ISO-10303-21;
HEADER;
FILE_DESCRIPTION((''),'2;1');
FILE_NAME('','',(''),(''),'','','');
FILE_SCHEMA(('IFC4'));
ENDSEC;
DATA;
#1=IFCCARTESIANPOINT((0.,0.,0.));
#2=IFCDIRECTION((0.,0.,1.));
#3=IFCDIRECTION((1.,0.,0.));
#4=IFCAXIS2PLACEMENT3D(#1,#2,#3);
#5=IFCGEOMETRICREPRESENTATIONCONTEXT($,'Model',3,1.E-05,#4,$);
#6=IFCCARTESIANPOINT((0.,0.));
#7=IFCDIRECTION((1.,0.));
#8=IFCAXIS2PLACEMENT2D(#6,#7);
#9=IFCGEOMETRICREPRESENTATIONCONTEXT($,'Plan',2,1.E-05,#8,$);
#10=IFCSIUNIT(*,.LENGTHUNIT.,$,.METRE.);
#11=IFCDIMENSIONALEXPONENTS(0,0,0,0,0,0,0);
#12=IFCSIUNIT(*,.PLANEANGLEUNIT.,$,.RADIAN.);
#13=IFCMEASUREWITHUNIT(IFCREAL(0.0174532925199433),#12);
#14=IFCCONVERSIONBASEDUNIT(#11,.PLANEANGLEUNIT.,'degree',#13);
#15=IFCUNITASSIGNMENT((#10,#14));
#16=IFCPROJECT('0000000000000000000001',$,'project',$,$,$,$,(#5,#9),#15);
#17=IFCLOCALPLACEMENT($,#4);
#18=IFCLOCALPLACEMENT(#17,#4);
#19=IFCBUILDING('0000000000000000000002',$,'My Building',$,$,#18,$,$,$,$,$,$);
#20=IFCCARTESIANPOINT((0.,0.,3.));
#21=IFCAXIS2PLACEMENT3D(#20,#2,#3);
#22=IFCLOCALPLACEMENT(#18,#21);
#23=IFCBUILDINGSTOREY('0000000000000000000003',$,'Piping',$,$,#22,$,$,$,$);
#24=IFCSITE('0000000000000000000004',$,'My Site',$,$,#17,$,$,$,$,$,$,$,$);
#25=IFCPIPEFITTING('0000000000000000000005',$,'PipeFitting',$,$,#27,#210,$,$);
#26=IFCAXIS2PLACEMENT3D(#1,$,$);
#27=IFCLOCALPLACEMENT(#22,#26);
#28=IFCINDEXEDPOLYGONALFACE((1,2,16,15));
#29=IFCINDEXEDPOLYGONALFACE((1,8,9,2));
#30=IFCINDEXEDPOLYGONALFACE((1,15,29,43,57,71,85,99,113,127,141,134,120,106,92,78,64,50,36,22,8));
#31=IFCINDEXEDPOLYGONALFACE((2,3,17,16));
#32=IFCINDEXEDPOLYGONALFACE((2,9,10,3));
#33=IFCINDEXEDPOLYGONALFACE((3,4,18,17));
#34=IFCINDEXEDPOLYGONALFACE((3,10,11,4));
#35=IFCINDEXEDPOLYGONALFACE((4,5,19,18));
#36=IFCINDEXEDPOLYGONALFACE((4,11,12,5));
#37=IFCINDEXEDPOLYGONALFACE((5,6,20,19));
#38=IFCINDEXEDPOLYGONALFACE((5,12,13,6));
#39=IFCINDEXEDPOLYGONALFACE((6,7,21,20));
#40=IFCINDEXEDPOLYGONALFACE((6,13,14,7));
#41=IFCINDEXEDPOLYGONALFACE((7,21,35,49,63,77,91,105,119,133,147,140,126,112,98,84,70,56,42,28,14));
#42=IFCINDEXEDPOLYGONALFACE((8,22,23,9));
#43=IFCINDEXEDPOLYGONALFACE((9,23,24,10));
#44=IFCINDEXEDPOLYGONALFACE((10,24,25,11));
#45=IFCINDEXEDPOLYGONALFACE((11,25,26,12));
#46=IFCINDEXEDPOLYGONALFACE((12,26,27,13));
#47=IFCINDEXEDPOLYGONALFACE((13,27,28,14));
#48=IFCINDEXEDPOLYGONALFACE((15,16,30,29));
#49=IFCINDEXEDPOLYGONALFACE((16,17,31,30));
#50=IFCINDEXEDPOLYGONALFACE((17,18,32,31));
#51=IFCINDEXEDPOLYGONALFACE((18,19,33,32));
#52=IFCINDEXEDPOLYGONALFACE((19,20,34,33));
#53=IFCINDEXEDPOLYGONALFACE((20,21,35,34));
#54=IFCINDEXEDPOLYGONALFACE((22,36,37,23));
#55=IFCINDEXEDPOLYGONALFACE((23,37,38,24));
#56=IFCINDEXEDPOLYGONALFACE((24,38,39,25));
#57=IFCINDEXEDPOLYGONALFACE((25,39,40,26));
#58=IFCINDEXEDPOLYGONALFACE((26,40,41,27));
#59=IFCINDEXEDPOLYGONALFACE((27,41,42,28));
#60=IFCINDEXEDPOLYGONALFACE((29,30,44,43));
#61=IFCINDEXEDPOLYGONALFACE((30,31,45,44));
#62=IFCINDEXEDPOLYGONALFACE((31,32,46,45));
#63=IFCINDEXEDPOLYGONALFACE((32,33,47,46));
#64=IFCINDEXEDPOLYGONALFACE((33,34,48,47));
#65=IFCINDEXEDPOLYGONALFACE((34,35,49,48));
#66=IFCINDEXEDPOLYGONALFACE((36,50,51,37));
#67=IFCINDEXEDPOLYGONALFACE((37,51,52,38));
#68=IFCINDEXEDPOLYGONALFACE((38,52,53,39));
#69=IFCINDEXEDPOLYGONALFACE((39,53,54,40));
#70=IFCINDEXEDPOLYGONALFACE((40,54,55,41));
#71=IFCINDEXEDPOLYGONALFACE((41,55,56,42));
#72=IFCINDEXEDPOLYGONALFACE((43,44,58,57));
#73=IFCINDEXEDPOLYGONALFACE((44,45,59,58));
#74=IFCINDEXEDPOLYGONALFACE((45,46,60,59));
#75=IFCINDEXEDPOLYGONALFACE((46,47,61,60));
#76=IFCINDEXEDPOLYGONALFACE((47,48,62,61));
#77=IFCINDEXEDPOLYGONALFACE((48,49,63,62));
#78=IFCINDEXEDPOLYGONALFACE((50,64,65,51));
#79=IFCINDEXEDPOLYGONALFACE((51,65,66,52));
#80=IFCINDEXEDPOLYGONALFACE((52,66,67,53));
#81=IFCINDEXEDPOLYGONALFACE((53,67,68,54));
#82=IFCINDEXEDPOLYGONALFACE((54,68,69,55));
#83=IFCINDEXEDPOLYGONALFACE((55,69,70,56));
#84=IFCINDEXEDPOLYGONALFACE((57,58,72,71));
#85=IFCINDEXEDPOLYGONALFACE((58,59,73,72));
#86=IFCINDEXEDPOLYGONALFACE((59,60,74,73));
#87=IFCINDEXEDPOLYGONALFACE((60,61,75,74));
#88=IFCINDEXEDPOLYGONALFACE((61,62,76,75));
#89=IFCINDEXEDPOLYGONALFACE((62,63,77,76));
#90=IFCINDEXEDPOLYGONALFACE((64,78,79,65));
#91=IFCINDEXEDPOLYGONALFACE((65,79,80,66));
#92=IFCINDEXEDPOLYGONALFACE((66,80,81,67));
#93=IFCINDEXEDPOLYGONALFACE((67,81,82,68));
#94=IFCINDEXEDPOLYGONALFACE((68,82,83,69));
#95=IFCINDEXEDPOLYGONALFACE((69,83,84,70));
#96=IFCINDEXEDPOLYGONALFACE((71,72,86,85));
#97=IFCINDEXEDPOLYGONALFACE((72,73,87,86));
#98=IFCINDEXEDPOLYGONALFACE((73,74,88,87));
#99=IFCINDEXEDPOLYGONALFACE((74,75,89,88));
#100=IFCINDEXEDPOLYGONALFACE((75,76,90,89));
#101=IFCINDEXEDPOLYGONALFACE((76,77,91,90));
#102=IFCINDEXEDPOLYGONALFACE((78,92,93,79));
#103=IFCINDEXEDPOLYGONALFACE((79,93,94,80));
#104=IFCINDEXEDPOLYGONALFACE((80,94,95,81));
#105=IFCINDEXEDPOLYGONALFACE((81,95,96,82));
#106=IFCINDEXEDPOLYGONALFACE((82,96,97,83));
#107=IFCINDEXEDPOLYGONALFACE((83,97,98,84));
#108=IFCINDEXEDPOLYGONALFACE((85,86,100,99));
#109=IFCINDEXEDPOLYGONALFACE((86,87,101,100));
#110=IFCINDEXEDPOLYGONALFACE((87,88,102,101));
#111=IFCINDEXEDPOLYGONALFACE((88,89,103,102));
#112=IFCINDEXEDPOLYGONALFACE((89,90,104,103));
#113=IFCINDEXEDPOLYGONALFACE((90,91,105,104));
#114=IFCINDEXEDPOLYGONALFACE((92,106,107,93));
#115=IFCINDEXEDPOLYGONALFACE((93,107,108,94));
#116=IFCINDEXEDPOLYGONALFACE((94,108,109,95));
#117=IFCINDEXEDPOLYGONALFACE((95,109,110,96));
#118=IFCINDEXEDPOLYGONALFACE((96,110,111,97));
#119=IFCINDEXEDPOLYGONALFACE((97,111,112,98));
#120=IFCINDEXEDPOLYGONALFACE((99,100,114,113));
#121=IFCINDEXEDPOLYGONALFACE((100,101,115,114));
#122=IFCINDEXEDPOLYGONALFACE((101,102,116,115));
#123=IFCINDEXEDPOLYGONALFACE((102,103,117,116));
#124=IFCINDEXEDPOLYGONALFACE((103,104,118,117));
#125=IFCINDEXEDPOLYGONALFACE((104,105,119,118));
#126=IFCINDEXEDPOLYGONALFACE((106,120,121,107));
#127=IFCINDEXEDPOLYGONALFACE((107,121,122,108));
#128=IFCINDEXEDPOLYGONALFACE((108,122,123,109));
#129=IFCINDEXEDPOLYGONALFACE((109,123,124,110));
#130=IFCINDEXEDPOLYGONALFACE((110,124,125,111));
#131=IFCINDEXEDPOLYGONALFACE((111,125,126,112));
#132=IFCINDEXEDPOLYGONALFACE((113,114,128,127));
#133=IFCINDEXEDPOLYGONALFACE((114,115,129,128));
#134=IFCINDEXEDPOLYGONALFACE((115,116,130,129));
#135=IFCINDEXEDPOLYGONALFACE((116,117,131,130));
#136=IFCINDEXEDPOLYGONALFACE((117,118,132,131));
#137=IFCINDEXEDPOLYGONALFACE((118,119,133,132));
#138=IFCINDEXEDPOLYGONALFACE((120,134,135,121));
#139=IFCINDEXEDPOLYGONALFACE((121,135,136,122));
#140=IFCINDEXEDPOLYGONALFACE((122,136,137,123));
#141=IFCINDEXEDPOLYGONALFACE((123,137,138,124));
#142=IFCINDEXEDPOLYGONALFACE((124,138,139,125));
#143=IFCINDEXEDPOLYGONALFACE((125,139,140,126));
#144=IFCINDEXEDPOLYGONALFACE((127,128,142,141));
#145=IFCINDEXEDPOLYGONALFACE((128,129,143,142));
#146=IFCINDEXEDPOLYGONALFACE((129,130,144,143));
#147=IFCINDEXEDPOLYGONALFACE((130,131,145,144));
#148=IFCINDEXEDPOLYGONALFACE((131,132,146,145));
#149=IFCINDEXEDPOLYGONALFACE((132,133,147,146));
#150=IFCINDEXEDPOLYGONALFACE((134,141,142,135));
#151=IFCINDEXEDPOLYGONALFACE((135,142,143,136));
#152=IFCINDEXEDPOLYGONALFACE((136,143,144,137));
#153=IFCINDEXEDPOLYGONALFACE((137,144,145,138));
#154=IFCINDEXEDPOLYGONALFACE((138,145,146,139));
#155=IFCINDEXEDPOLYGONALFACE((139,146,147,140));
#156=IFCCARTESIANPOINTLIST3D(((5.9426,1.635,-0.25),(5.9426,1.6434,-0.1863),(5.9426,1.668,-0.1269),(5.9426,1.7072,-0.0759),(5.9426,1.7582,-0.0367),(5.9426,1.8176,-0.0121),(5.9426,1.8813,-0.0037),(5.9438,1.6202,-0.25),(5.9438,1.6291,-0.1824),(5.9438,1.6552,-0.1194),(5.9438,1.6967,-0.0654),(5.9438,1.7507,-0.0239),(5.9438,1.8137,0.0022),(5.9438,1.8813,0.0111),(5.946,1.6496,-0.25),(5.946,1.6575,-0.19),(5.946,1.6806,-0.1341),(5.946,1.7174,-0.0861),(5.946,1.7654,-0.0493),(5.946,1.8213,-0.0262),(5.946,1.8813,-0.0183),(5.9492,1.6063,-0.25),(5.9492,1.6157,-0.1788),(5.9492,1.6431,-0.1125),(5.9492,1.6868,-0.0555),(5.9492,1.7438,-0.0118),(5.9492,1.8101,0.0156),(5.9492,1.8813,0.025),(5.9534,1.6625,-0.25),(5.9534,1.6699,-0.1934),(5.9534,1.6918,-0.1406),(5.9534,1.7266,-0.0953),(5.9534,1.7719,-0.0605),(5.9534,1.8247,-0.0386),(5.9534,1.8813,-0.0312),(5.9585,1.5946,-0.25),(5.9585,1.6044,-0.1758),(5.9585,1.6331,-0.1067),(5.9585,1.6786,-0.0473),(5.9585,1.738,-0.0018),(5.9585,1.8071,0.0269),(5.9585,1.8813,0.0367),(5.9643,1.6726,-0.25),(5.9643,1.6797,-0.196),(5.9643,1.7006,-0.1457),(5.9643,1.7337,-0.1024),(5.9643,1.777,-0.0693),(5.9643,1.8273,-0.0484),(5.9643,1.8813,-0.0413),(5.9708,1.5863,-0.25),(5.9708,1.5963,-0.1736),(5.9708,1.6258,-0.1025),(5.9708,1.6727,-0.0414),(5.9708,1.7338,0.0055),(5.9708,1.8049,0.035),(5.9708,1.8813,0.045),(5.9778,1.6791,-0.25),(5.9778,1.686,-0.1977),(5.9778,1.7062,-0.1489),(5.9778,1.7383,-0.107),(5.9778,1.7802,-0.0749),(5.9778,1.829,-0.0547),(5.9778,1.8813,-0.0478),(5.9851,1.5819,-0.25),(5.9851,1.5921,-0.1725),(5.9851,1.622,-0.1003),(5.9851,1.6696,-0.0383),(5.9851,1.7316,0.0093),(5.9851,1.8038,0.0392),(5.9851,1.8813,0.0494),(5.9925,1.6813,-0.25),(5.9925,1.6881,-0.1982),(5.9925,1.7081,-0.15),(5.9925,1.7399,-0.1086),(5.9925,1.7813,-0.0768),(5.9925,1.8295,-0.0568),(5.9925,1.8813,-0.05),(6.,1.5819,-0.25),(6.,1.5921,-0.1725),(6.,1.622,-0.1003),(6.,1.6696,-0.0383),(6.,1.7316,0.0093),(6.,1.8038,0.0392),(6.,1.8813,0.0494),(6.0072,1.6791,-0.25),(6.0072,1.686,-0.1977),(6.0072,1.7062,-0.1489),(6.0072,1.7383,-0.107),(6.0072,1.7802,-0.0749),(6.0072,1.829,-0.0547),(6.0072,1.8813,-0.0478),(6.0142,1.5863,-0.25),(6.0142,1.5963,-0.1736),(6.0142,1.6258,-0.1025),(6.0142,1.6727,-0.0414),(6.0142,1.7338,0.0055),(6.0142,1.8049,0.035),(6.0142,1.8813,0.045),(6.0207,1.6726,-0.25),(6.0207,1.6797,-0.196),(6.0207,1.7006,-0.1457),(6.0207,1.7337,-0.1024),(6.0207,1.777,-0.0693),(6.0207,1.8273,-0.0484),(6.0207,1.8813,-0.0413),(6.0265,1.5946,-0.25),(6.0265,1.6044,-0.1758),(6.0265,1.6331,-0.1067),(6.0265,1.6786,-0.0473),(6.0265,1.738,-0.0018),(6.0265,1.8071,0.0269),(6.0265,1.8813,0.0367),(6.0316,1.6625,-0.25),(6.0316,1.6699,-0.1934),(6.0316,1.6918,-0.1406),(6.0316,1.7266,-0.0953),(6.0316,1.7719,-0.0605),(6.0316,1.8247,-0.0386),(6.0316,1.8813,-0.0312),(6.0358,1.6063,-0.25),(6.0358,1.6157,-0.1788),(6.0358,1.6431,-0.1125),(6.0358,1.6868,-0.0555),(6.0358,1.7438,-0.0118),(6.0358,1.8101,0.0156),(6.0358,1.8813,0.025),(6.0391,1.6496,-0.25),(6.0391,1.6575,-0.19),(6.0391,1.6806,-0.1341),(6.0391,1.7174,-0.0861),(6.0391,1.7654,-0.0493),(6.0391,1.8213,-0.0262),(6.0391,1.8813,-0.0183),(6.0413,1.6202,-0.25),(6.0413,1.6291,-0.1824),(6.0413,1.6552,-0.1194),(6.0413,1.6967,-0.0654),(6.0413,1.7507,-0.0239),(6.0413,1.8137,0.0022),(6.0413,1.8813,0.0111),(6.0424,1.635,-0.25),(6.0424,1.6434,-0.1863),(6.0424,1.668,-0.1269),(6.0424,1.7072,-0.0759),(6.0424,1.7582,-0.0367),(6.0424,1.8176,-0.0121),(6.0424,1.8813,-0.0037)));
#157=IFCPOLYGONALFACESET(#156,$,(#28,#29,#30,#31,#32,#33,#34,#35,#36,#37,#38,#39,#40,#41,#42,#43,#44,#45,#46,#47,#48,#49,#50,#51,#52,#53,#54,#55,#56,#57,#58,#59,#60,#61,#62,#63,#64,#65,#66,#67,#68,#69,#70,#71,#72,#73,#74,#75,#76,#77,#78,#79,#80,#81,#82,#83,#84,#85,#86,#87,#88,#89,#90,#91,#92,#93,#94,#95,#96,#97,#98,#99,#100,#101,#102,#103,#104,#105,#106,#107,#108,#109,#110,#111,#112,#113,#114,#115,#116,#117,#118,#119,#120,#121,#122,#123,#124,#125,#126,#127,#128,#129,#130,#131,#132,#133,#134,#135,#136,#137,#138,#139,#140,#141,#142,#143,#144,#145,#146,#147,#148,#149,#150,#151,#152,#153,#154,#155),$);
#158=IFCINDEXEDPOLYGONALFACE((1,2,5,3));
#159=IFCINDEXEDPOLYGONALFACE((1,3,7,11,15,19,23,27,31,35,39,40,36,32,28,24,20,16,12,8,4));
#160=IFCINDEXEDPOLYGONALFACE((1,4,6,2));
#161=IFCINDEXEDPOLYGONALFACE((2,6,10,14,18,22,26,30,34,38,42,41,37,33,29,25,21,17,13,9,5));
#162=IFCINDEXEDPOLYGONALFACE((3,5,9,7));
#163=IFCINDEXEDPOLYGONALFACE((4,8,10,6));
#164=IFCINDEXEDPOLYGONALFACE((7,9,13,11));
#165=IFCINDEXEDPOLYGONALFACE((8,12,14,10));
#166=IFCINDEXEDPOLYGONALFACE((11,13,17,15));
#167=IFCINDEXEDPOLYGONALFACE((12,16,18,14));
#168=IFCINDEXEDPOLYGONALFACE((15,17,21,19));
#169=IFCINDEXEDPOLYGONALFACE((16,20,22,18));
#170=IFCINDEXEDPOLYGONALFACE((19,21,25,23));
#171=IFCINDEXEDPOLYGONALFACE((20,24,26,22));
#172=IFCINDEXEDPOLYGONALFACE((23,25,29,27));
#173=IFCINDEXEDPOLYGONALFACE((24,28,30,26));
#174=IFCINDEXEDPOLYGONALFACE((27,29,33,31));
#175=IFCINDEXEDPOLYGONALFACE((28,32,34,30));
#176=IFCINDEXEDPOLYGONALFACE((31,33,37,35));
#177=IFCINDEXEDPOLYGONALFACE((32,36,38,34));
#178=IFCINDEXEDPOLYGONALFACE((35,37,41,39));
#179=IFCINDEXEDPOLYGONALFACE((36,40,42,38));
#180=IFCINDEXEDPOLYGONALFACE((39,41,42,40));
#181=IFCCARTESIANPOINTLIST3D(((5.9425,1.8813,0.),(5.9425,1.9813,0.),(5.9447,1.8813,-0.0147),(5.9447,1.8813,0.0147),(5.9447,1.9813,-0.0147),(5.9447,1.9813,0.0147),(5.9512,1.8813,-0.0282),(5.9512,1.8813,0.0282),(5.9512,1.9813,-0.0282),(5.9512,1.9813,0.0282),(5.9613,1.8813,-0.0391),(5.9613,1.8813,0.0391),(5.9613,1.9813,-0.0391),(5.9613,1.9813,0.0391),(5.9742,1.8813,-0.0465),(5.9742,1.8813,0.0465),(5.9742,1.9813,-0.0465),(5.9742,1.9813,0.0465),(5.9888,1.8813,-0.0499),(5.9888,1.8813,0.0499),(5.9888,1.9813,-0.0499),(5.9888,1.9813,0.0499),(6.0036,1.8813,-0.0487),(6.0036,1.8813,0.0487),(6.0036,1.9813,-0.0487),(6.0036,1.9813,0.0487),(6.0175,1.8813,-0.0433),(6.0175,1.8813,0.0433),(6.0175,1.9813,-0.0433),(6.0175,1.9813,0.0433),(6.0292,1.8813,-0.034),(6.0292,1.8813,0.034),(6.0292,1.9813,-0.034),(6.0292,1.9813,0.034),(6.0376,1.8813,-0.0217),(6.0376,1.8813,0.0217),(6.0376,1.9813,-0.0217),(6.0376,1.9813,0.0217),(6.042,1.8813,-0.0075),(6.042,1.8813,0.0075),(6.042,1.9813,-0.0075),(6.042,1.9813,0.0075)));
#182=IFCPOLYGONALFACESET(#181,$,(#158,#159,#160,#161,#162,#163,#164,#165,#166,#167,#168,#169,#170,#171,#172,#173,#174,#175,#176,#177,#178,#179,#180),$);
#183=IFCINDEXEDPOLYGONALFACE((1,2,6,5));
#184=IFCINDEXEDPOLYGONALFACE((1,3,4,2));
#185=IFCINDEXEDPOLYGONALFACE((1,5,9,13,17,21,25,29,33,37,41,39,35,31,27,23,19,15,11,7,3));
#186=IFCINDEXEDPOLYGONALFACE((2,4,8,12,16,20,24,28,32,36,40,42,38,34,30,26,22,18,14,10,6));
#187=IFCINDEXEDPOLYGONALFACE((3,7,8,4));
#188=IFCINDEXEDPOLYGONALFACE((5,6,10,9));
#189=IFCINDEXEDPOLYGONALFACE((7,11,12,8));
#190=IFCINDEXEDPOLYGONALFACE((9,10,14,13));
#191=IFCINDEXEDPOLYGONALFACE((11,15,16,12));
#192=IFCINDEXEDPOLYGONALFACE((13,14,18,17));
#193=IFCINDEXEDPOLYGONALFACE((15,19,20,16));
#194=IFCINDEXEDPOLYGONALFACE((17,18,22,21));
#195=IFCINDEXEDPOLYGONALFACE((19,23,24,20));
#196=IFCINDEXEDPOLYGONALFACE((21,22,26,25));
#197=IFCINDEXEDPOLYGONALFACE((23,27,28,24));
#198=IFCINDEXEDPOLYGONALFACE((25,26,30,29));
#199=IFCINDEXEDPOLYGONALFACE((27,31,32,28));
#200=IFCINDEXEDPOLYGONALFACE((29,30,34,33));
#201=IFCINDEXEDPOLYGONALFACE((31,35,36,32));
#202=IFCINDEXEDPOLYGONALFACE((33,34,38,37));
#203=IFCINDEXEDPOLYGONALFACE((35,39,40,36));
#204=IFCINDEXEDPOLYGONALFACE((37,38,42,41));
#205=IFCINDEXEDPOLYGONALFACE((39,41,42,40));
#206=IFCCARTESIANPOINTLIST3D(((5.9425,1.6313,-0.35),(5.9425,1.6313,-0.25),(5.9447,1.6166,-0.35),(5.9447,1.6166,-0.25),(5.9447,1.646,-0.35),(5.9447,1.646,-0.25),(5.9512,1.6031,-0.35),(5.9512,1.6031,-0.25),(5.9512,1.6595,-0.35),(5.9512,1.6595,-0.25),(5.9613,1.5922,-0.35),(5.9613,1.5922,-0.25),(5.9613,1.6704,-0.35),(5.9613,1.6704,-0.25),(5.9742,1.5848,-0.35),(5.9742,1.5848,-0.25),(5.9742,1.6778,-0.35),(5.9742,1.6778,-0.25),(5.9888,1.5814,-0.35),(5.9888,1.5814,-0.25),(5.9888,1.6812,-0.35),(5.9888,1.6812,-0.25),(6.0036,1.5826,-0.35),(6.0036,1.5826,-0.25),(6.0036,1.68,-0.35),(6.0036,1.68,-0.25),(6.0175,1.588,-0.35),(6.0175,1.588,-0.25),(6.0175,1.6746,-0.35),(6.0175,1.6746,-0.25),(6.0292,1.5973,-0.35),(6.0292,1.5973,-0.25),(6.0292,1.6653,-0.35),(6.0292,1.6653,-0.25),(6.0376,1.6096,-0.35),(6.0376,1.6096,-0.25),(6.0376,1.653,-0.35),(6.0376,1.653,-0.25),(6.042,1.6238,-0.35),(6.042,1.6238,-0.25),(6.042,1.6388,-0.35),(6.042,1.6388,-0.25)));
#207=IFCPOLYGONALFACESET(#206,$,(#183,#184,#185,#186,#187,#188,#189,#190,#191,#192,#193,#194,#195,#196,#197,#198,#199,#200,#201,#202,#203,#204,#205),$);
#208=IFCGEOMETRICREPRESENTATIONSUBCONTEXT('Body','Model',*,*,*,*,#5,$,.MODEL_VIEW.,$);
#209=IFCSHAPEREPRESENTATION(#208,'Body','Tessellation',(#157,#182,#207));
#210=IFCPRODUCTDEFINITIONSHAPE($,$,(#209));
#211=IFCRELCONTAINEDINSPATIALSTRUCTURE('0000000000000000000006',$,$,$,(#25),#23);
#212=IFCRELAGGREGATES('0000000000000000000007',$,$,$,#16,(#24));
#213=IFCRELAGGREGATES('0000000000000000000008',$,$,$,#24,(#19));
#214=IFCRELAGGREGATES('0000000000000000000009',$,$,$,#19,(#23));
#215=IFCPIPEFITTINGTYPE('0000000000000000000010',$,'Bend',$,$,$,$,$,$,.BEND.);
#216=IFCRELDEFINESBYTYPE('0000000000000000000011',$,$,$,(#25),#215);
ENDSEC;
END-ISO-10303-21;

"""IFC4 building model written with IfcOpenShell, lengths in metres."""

from ifc_helpers import new_model, entity, si_unit, converted_unit, frame, origin_with_axes, origin_2d_with_axis, place, context, subcontext, project, spatial, circle, extrude, source, transform, mapped, type_object, type_shapes, element, save


model = new_model("IFC4")

# Units and contexts
model_context = context("Model", 3, precision=1e-05, world=origin_with_axes())
plan_context = context("Plan", 2, precision=1e-05, world=origin_2d_with_axis())
body_context = subcontext(model_context, "Body", "Model", "MODEL_VIEW")
ifc_project = project(units=[si_unit("LENGTHUNIT", "METRE"), converted_unit("PLANEANGLEUNIT", "degree", entity("IfcReal", 0.0174532925199433), si_unit("PLANEANGLEUNIT", "RADIAN"), dimensions=[0, 0, 0, 0, 0, 0, 0])], contexts=[model_context, plan_context])

# Site, building, storey
site_placement = place(None, origin_with_axes())
site = spatial("IfcSite", under=ifc_project, at=site_placement, Name="My Site")
building_placement = place(site_placement, origin_with_axes())
building = spatial("IfcBuilding", under=site, at=building_placement, Name="My Building")
storey_placement = place(building_placement, frame((0.0, 0.0, 3.0), z_axis=(0.0, 0.0, 1.0), x_axis=(1.0, 0.0, 0.0)))
storey = spatial("IfcBuildingStorey", under=building, at=storey_placement, Name="Piping")

# Pipe fitting
pipe_fitting_type = type_object("IfcPipeFittingType", Name="Bend", PredefinedType="BEND")
shared_shape = source(origin_with_axes(), body_context, "Body", "SolidModel", [
    entity("IfcSweptDiskSolid", entity("IfcIndexedPolyCurve", entity("IfcCartesianPointList3D", [[0.0, 0.0, -0.1], [0.0, -0.0732, -0.2768], [0.0, -0.25, -0.35]]), [entity("IfcArcIndex", [1, 2, 3])]), 0.05),
    extrude(circle(Radius=0.05), origin_with_axes(), (0.0, 0.0, -1.0), 0.1),
    extrude(circle(Radius=0.05), frame((0.0, -0.25, -0.35), z_axis=(0.0, -1.0, 0.0), x_axis=(1.0, 0.0, 0.0)), (0.0, 0.0, 1.0), 0.1),
])
type_shapes(pipe_fitting_type, [shared_shape])
for number, where, z_axis, x_axis, name in (
    (1, (5.9925, 1.9813, 0.0), (0.0, 1.0, 0.0), (-1.0, 0.0, 0.0), "PipeFitting"),
):
    element("IfcPipeFitting", number, at=place(storey_placement, frame(where, z_axis=z_axis, x_axis=x_axis)), inside=storey, type_object=pipe_fitting_type, Name=name, context=body_context, shape_type="MappedRepresentation", body=[
        mapped(shared_shape, transform((0.0, 0.0, 0.0), x_axis=(1.0, 0.0, 0.0), y_axis=(0.0, 1.0, 0.0), z_axis=(0.0, 0.0, 1.0), scale=1.0)),
    ])

save(model, "model.ifc")
